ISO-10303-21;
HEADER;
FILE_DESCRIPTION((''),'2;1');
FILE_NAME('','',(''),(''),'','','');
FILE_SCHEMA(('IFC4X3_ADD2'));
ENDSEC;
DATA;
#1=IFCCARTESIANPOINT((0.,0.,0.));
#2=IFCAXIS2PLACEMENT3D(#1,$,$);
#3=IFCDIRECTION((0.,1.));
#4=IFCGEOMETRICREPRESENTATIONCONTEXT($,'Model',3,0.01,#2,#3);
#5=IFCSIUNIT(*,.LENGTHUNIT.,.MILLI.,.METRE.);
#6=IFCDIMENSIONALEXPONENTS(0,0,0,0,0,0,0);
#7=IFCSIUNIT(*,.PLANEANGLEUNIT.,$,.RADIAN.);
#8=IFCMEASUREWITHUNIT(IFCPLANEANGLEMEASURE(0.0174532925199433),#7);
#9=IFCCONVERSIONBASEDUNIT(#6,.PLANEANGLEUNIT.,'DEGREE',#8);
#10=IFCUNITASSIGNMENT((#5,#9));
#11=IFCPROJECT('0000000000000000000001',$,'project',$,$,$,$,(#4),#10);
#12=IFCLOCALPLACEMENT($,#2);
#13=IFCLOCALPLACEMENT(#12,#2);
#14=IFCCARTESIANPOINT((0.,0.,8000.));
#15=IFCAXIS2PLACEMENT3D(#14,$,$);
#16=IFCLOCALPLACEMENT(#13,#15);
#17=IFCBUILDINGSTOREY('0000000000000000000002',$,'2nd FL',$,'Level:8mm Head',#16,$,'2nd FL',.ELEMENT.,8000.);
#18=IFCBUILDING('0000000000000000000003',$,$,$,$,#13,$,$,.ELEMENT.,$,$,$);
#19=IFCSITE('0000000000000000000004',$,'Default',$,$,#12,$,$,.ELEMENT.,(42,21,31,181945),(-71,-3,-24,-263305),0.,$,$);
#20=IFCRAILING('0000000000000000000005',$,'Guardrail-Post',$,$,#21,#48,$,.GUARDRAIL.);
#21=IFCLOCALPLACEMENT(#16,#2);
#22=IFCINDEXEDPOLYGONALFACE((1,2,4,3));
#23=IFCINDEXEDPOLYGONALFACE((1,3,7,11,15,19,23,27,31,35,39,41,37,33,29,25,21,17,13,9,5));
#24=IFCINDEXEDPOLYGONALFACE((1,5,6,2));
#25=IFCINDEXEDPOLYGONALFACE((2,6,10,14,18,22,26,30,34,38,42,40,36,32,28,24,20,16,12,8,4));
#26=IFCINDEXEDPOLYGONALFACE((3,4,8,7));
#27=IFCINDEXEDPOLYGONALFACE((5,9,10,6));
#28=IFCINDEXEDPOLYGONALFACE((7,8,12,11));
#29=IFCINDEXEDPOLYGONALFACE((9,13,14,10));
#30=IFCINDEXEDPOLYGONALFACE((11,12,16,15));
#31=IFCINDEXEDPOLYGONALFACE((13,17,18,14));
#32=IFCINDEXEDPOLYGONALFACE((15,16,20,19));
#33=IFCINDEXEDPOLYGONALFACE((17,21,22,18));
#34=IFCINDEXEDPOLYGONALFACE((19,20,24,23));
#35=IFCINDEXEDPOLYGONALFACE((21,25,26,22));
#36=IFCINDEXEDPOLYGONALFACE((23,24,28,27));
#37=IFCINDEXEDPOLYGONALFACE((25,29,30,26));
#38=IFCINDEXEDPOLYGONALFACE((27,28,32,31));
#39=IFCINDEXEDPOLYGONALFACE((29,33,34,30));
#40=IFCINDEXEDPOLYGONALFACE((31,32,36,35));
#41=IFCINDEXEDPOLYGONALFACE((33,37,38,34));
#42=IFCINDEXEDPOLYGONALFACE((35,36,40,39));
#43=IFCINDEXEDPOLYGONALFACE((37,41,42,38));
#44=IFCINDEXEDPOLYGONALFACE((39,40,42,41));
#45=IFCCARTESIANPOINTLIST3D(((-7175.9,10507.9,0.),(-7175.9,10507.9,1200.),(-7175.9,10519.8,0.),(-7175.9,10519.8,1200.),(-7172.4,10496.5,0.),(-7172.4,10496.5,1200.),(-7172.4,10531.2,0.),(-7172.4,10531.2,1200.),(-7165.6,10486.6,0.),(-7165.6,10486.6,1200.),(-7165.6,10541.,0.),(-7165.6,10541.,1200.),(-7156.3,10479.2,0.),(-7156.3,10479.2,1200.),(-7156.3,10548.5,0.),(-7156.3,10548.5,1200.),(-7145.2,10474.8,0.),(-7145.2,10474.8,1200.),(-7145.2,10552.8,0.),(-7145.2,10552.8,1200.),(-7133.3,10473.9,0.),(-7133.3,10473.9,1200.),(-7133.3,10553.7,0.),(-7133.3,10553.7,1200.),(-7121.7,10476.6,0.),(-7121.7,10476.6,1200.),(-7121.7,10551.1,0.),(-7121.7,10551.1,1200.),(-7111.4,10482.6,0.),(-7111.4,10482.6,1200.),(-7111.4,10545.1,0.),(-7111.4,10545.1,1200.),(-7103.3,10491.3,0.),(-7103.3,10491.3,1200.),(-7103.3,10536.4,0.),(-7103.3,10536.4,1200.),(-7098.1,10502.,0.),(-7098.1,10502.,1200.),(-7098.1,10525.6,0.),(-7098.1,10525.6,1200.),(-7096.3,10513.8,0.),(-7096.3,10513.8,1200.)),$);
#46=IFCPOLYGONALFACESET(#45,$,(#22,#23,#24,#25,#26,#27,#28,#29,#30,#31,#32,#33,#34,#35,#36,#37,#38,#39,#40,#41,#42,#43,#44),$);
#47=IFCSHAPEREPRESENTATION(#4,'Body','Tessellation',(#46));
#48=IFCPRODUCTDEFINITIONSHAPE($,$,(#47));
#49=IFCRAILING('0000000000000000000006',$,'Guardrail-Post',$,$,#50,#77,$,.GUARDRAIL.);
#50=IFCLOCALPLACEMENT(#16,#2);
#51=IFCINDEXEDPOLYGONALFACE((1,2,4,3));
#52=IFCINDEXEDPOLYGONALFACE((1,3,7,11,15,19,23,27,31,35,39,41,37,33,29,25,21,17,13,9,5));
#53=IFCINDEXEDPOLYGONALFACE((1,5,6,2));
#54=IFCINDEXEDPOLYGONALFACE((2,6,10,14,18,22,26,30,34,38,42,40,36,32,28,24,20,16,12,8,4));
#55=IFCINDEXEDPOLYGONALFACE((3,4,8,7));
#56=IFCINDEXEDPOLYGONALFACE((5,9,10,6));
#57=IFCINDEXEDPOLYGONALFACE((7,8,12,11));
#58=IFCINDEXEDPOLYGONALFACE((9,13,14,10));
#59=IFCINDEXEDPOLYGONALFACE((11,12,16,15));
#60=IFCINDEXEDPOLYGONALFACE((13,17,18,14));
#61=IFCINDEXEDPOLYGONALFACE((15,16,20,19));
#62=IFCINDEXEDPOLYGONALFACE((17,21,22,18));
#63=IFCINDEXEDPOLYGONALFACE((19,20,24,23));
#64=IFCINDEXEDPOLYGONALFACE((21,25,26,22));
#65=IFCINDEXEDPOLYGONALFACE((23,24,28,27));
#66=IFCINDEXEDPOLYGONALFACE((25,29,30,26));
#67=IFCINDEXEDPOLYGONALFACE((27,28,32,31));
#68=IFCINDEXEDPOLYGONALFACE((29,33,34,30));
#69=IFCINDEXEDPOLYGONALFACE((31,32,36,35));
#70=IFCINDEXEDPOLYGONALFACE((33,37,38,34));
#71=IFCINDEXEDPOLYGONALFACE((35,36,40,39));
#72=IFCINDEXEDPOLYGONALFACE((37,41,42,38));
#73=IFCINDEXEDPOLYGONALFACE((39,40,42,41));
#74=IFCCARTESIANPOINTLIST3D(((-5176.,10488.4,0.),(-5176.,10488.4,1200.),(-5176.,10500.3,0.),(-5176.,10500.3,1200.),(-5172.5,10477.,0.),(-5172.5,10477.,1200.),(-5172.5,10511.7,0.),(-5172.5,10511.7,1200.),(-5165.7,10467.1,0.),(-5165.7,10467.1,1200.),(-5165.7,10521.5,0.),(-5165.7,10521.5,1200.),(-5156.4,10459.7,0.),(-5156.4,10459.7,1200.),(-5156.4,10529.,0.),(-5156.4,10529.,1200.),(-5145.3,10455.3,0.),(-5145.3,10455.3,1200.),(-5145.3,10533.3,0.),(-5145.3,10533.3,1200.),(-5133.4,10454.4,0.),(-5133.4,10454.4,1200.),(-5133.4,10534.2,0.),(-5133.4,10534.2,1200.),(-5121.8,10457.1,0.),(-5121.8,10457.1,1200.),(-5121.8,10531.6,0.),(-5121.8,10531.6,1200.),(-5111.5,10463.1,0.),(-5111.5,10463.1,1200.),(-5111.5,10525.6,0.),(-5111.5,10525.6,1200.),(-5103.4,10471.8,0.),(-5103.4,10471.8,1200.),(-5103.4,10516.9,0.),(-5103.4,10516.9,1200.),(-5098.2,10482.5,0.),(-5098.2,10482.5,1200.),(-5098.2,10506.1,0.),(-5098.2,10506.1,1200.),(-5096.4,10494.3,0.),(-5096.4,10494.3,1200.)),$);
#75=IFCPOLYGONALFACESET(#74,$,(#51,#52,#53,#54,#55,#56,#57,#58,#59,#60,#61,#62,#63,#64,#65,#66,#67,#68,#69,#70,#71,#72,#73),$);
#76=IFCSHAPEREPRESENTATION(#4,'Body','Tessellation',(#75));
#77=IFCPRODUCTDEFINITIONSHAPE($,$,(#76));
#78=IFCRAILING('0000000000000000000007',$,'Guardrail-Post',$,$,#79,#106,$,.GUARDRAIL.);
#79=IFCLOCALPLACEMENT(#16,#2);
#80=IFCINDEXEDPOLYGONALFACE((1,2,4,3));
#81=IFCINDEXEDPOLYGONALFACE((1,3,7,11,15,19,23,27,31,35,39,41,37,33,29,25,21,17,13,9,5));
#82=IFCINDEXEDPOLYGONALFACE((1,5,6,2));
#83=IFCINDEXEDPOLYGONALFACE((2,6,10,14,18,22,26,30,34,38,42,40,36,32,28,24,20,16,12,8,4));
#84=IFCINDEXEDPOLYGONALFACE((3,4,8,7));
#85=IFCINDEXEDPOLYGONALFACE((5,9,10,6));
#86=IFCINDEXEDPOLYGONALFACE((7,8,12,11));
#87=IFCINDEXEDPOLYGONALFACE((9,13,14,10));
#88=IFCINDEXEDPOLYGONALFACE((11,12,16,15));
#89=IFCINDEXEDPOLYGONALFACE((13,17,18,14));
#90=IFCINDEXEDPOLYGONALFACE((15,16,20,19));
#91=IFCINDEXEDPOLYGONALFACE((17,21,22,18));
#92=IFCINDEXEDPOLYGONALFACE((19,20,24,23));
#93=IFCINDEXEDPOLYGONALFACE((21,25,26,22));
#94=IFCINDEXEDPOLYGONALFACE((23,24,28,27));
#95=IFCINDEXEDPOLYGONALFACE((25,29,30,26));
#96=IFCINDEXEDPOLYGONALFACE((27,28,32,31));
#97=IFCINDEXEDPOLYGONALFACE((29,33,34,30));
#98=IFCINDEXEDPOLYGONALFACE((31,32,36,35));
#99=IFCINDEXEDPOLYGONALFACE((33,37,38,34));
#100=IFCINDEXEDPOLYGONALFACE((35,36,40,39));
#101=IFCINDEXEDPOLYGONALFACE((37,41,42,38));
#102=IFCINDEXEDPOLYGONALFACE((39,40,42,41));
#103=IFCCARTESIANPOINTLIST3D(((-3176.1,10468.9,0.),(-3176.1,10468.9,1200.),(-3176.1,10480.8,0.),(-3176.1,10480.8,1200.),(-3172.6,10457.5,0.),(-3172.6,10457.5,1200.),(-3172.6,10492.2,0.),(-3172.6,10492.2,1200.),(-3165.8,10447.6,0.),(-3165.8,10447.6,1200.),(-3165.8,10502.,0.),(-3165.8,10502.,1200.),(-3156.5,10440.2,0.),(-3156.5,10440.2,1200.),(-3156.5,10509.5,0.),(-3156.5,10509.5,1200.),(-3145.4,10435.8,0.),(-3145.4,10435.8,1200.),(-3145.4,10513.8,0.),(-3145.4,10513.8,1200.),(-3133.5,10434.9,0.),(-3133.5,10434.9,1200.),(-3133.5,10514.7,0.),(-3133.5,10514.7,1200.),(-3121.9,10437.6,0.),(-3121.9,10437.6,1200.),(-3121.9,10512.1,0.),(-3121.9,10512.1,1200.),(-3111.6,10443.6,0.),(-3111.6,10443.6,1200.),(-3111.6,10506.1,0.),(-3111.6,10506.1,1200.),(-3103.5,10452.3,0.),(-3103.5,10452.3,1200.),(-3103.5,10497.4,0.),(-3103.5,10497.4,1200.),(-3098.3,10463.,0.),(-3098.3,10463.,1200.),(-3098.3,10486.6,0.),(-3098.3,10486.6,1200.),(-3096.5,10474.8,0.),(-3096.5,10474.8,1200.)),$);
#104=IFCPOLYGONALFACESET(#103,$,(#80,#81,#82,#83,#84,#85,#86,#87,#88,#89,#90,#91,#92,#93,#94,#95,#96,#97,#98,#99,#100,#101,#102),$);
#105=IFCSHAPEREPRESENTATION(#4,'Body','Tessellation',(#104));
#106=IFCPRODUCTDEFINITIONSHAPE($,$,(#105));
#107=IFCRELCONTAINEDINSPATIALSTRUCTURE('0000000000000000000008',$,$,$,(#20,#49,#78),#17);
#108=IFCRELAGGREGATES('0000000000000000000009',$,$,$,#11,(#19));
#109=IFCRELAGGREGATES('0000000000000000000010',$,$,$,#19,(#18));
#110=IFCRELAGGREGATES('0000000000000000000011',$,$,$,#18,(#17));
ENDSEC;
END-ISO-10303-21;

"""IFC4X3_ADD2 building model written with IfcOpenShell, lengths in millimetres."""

from ifc_helpers import new_model, entity, si_unit, converted_unit, direction, frame, origin, origin_with_axes, origin_2d, place, context, project, spatial, circle, extrude, element, save


model = new_model("IFC4X3_ADD2")

# Units and contexts
model_context = context("Model", 3, precision=0.01, world=origin(), true_north=direction((0.0, 1.0)))
ifc_project = project(units=[si_unit("LENGTHUNIT", "METRE", prefix="MILLI"), converted_unit("PLANEANGLEUNIT", "DEGREE", entity("IfcPlaneAngleMeasure", 0.0174532925199433), si_unit("PLANEANGLEUNIT", "RADIAN"), dimensions=[0, 0, 0, 0, 0, 0, 0])], contexts=[model_context])

# Site, building, storey
site_placement = place(None, origin())
site = spatial("IfcSite", under=ifc_project, at=site_placement, Name="Default", CompositionType="ELEMENT", RefLatitude=(42, 21, 31, 181945), RefLongitude=(-71, -3, -24, -263305), RefElevation=0.0)
building_placement = place(site_placement, origin())
building = spatial("IfcBuilding", under=site, at=building_placement, CompositionType="ELEMENT")
storey_placement = place(building_placement, frame((0.0, 0.0, 8000.0)))
storey = spatial("IfcBuildingStorey", under=building, at=storey_placement, Name="2nd FL", ObjectType="Level:8mm Head", LongName="2nd FL", CompositionType="ELEMENT", Elevation=8000.0)

# Railings
for number, where, z_axis, x_axis, name in (
    (1, (-7136.3, 10513.8, 8000.0), (0.0, 0.0, 1.0), (1.0, 0.0, 0.0), "Guardrail-Post"),
    (2, (-5136.4, 10494.3, 8000.0), (0.0, 0.0, 1.0), (1.0, 0.0, 0.0), "Guardrail-Post"),
    (3, (-3136.5, 10474.8, 8000.0), (0.0, 0.0, 1.0), (1.0, 0.0, 0.0), "Guardrail-Post"),
):
    element("IfcRailing", number, at=place(None, frame(where, z_axis=z_axis, x_axis=x_axis)), inside=storey, Name=name, PredefinedType="GUARDRAIL", context=model_context, shape_type="SweptSolid", body=[
        extrude(circle(Radius=40.0, at=origin_2d()), origin_with_axes(), (0.0, 0.0, 1.0), 1200.0),
    ])

save(model, "model.ifc")
